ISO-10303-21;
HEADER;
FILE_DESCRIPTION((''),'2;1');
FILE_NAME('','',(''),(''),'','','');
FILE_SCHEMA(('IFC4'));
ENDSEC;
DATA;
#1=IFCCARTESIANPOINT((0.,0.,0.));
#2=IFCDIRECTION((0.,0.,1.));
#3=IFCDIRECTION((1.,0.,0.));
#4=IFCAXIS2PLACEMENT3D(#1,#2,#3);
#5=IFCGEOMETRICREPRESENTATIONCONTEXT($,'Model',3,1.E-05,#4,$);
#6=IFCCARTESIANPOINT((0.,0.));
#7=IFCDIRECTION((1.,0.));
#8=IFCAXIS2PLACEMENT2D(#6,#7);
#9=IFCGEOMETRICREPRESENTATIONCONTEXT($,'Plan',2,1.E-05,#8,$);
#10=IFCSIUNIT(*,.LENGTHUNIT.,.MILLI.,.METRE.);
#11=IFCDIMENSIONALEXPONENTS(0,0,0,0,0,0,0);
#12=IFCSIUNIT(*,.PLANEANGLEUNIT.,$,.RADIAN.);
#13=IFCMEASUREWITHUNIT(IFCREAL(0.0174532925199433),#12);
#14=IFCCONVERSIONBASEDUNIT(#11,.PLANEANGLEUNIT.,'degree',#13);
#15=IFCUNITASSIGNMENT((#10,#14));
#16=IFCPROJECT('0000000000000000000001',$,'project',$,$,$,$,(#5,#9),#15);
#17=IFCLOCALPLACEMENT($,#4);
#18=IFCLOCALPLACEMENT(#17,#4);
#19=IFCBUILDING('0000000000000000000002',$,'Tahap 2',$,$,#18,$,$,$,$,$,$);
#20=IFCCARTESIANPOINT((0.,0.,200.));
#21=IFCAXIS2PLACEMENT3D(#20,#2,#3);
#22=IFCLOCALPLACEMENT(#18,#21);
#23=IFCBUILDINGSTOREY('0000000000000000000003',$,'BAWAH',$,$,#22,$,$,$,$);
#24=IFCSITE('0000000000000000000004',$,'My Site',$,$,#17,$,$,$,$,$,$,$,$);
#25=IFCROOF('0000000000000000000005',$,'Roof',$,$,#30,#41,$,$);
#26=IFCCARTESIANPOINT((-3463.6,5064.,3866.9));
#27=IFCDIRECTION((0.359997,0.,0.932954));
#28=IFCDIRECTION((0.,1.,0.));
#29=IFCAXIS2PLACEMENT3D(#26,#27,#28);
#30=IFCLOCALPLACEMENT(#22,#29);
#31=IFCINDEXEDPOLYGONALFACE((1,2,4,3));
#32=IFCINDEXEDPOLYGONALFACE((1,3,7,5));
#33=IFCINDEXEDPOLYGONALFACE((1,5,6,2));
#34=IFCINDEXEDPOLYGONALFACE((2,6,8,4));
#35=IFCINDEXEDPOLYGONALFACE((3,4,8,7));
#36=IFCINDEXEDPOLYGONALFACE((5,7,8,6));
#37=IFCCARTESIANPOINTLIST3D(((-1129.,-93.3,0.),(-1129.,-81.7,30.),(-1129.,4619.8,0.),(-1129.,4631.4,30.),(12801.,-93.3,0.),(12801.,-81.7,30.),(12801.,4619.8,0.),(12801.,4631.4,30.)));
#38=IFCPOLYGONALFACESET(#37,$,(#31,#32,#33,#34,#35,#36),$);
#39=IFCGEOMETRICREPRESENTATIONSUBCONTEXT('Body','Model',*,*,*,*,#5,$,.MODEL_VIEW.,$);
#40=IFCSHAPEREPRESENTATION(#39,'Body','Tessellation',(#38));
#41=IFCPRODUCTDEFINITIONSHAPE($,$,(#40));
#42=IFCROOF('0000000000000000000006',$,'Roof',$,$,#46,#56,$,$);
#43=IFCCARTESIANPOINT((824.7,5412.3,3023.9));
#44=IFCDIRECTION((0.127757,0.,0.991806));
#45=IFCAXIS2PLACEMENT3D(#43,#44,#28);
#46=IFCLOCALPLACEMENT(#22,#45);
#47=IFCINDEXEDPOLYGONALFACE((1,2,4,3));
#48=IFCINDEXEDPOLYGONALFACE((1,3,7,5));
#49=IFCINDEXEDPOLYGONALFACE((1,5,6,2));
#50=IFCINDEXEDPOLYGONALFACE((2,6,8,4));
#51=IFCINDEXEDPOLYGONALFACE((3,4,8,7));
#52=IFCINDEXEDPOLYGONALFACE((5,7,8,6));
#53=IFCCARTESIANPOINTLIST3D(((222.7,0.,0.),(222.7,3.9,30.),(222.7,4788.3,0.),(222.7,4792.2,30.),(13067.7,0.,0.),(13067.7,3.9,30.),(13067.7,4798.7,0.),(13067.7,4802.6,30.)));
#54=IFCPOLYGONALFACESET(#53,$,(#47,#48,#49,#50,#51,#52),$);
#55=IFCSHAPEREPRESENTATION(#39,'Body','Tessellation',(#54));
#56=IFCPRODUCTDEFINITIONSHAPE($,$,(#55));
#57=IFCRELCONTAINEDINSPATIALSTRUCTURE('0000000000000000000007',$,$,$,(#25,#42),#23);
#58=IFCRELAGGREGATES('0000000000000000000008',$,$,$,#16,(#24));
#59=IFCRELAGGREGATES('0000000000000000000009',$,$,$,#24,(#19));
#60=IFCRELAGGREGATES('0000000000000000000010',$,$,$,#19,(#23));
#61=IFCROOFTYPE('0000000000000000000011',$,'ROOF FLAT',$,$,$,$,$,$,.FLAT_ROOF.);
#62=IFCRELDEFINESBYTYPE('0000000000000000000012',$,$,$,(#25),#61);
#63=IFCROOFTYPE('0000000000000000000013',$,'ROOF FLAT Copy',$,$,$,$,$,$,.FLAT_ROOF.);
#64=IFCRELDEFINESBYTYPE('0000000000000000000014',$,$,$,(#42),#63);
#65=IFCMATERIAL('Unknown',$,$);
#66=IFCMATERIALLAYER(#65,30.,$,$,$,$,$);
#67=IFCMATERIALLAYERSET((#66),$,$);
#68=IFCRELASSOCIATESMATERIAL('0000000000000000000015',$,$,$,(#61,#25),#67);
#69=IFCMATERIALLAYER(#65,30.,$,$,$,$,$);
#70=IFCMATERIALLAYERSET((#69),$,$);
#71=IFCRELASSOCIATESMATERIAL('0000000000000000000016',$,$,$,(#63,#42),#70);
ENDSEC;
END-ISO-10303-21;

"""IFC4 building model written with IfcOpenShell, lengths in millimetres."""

from ifc_helpers import new_model, entity, si_unit, converted_unit, frame, origin_with_axes, origin_2d_with_axis, place, context, subcontext, project, spatial, indexed_curve, outline, extrude, material, layer, layer_set, layer_usage, type_object, element, save


model = new_model("IFC4")

# Units and contexts
model_context = context("Model", 3, precision=1e-05, world=origin_with_axes())
plan_context = context("Plan", 2, precision=1e-05, world=origin_2d_with_axis())
body_context = subcontext(model_context, "Body", "Model", "MODEL_VIEW")
ifc_project = project(units=[si_unit("LENGTHUNIT", "METRE", prefix="MILLI"), converted_unit("PLANEANGLEUNIT", "degree", entity("IfcReal", 0.0174532925199433), si_unit("PLANEANGLEUNIT", "RADIAN"), dimensions=[0, 0, 0, 0, 0, 0, 0])], contexts=[model_context, plan_context])

# Site, building, storey
site_placement = place(None, origin_with_axes())
site = spatial("IfcSite", under=ifc_project, at=site_placement, Name="My Site")
building_placement = place(site_placement, origin_with_axes())
building = spatial("IfcBuilding", under=site, at=building_placement, Name="Tahap 2")
storey_placement = place(building_placement, frame((0.0, 0.0, 200.0), z_axis=(0.0, 0.0, 1.0), x_axis=(1.0, 0.0, 0.0)))
storey = spatial("IfcBuildingStorey", under=building, at=storey_placement, Name="BAWAH")

# Shared definitions
ifc_material_1 = material(Name="Unknown")

# Roofs
ifc_layer_1 = layer(ifc_material_1, 30.0)
ifc_layer_set_1 = layer_set([ifc_layer_1])
ifc_layer_usage_1 = layer_usage(ifc_layer_set_1, "AXIS3", "NEGATIVE", 30.0)
roof_type_1 = type_object("IfcRoofType", Name="ROOF FLAT", PredefinedType="FLAT_ROOF", material=ifc_layer_set_1)
roof_1_placement = place(storey_placement, frame((-3463.6, 5064.0, 3866.9), z_axis=(0.359997, 0.0, 0.932954), x_axis=(0.0, 1.0, 0.0)))
element("IfcRoof", 1, at=roof_1_placement, inside=storey, type_object=roof_type_1, material=ifc_layer_usage_1, Name="Roof", context=body_context, shape_type="SweptSolid", body=[
    extrude(outline(indexed_curve([(-1129.0, 4619.8), (12801.0, 4619.8), (12801.0, -93.3), (-1129.0, -93.3), (-1129.0, 4619.8)])), frame((0.0, 11.6, 30.0), z_axis=(0.0, 0.0, 1.0), x_axis=(1.0, 0.0, 0.0)), (0.0, -0.359997, -0.932954), 32.2),
])
ifc_layer_2 = layer(ifc_material_1, 30.0)
ifc_layer_set_2 = layer_set([ifc_layer_2])
ifc_layer_usage_2 = layer_usage(ifc_layer_set_2, "AXIS3", "NEGATIVE", 30.0)
roof_type_2 = type_object("IfcRoofType", Name="ROOF FLAT Copy", PredefinedType="FLAT_ROOF", material=ifc_layer_set_2)
roof_2_placement = place(storey_placement, frame((824.7, 5412.3, 3023.9), z_axis=(0.127757, 0.0, 0.991806), x_axis=(0.0, 1.0, 0.0)))
element("IfcRoof", 2, at=roof_2_placement, inside=storey, type_object=roof_type_2, material=ifc_layer_usage_2, Name="Roof", context=body_context, shape_type="SweptSolid", body=[
    extrude(outline(indexed_curve([(222.7, 4788.3), (13067.7, 4798.7), (13067.7, 0.0), (222.7, 0.0), (222.7, 4788.3)])), frame((0.0, 3.9, 30.0), z_axis=(0.0, 0.0, 1.0), x_axis=(1.0, 0.0, 0.0)), (0.0, -0.127757, -0.991805), 30.2),
])

save(model, "model.ifc")
